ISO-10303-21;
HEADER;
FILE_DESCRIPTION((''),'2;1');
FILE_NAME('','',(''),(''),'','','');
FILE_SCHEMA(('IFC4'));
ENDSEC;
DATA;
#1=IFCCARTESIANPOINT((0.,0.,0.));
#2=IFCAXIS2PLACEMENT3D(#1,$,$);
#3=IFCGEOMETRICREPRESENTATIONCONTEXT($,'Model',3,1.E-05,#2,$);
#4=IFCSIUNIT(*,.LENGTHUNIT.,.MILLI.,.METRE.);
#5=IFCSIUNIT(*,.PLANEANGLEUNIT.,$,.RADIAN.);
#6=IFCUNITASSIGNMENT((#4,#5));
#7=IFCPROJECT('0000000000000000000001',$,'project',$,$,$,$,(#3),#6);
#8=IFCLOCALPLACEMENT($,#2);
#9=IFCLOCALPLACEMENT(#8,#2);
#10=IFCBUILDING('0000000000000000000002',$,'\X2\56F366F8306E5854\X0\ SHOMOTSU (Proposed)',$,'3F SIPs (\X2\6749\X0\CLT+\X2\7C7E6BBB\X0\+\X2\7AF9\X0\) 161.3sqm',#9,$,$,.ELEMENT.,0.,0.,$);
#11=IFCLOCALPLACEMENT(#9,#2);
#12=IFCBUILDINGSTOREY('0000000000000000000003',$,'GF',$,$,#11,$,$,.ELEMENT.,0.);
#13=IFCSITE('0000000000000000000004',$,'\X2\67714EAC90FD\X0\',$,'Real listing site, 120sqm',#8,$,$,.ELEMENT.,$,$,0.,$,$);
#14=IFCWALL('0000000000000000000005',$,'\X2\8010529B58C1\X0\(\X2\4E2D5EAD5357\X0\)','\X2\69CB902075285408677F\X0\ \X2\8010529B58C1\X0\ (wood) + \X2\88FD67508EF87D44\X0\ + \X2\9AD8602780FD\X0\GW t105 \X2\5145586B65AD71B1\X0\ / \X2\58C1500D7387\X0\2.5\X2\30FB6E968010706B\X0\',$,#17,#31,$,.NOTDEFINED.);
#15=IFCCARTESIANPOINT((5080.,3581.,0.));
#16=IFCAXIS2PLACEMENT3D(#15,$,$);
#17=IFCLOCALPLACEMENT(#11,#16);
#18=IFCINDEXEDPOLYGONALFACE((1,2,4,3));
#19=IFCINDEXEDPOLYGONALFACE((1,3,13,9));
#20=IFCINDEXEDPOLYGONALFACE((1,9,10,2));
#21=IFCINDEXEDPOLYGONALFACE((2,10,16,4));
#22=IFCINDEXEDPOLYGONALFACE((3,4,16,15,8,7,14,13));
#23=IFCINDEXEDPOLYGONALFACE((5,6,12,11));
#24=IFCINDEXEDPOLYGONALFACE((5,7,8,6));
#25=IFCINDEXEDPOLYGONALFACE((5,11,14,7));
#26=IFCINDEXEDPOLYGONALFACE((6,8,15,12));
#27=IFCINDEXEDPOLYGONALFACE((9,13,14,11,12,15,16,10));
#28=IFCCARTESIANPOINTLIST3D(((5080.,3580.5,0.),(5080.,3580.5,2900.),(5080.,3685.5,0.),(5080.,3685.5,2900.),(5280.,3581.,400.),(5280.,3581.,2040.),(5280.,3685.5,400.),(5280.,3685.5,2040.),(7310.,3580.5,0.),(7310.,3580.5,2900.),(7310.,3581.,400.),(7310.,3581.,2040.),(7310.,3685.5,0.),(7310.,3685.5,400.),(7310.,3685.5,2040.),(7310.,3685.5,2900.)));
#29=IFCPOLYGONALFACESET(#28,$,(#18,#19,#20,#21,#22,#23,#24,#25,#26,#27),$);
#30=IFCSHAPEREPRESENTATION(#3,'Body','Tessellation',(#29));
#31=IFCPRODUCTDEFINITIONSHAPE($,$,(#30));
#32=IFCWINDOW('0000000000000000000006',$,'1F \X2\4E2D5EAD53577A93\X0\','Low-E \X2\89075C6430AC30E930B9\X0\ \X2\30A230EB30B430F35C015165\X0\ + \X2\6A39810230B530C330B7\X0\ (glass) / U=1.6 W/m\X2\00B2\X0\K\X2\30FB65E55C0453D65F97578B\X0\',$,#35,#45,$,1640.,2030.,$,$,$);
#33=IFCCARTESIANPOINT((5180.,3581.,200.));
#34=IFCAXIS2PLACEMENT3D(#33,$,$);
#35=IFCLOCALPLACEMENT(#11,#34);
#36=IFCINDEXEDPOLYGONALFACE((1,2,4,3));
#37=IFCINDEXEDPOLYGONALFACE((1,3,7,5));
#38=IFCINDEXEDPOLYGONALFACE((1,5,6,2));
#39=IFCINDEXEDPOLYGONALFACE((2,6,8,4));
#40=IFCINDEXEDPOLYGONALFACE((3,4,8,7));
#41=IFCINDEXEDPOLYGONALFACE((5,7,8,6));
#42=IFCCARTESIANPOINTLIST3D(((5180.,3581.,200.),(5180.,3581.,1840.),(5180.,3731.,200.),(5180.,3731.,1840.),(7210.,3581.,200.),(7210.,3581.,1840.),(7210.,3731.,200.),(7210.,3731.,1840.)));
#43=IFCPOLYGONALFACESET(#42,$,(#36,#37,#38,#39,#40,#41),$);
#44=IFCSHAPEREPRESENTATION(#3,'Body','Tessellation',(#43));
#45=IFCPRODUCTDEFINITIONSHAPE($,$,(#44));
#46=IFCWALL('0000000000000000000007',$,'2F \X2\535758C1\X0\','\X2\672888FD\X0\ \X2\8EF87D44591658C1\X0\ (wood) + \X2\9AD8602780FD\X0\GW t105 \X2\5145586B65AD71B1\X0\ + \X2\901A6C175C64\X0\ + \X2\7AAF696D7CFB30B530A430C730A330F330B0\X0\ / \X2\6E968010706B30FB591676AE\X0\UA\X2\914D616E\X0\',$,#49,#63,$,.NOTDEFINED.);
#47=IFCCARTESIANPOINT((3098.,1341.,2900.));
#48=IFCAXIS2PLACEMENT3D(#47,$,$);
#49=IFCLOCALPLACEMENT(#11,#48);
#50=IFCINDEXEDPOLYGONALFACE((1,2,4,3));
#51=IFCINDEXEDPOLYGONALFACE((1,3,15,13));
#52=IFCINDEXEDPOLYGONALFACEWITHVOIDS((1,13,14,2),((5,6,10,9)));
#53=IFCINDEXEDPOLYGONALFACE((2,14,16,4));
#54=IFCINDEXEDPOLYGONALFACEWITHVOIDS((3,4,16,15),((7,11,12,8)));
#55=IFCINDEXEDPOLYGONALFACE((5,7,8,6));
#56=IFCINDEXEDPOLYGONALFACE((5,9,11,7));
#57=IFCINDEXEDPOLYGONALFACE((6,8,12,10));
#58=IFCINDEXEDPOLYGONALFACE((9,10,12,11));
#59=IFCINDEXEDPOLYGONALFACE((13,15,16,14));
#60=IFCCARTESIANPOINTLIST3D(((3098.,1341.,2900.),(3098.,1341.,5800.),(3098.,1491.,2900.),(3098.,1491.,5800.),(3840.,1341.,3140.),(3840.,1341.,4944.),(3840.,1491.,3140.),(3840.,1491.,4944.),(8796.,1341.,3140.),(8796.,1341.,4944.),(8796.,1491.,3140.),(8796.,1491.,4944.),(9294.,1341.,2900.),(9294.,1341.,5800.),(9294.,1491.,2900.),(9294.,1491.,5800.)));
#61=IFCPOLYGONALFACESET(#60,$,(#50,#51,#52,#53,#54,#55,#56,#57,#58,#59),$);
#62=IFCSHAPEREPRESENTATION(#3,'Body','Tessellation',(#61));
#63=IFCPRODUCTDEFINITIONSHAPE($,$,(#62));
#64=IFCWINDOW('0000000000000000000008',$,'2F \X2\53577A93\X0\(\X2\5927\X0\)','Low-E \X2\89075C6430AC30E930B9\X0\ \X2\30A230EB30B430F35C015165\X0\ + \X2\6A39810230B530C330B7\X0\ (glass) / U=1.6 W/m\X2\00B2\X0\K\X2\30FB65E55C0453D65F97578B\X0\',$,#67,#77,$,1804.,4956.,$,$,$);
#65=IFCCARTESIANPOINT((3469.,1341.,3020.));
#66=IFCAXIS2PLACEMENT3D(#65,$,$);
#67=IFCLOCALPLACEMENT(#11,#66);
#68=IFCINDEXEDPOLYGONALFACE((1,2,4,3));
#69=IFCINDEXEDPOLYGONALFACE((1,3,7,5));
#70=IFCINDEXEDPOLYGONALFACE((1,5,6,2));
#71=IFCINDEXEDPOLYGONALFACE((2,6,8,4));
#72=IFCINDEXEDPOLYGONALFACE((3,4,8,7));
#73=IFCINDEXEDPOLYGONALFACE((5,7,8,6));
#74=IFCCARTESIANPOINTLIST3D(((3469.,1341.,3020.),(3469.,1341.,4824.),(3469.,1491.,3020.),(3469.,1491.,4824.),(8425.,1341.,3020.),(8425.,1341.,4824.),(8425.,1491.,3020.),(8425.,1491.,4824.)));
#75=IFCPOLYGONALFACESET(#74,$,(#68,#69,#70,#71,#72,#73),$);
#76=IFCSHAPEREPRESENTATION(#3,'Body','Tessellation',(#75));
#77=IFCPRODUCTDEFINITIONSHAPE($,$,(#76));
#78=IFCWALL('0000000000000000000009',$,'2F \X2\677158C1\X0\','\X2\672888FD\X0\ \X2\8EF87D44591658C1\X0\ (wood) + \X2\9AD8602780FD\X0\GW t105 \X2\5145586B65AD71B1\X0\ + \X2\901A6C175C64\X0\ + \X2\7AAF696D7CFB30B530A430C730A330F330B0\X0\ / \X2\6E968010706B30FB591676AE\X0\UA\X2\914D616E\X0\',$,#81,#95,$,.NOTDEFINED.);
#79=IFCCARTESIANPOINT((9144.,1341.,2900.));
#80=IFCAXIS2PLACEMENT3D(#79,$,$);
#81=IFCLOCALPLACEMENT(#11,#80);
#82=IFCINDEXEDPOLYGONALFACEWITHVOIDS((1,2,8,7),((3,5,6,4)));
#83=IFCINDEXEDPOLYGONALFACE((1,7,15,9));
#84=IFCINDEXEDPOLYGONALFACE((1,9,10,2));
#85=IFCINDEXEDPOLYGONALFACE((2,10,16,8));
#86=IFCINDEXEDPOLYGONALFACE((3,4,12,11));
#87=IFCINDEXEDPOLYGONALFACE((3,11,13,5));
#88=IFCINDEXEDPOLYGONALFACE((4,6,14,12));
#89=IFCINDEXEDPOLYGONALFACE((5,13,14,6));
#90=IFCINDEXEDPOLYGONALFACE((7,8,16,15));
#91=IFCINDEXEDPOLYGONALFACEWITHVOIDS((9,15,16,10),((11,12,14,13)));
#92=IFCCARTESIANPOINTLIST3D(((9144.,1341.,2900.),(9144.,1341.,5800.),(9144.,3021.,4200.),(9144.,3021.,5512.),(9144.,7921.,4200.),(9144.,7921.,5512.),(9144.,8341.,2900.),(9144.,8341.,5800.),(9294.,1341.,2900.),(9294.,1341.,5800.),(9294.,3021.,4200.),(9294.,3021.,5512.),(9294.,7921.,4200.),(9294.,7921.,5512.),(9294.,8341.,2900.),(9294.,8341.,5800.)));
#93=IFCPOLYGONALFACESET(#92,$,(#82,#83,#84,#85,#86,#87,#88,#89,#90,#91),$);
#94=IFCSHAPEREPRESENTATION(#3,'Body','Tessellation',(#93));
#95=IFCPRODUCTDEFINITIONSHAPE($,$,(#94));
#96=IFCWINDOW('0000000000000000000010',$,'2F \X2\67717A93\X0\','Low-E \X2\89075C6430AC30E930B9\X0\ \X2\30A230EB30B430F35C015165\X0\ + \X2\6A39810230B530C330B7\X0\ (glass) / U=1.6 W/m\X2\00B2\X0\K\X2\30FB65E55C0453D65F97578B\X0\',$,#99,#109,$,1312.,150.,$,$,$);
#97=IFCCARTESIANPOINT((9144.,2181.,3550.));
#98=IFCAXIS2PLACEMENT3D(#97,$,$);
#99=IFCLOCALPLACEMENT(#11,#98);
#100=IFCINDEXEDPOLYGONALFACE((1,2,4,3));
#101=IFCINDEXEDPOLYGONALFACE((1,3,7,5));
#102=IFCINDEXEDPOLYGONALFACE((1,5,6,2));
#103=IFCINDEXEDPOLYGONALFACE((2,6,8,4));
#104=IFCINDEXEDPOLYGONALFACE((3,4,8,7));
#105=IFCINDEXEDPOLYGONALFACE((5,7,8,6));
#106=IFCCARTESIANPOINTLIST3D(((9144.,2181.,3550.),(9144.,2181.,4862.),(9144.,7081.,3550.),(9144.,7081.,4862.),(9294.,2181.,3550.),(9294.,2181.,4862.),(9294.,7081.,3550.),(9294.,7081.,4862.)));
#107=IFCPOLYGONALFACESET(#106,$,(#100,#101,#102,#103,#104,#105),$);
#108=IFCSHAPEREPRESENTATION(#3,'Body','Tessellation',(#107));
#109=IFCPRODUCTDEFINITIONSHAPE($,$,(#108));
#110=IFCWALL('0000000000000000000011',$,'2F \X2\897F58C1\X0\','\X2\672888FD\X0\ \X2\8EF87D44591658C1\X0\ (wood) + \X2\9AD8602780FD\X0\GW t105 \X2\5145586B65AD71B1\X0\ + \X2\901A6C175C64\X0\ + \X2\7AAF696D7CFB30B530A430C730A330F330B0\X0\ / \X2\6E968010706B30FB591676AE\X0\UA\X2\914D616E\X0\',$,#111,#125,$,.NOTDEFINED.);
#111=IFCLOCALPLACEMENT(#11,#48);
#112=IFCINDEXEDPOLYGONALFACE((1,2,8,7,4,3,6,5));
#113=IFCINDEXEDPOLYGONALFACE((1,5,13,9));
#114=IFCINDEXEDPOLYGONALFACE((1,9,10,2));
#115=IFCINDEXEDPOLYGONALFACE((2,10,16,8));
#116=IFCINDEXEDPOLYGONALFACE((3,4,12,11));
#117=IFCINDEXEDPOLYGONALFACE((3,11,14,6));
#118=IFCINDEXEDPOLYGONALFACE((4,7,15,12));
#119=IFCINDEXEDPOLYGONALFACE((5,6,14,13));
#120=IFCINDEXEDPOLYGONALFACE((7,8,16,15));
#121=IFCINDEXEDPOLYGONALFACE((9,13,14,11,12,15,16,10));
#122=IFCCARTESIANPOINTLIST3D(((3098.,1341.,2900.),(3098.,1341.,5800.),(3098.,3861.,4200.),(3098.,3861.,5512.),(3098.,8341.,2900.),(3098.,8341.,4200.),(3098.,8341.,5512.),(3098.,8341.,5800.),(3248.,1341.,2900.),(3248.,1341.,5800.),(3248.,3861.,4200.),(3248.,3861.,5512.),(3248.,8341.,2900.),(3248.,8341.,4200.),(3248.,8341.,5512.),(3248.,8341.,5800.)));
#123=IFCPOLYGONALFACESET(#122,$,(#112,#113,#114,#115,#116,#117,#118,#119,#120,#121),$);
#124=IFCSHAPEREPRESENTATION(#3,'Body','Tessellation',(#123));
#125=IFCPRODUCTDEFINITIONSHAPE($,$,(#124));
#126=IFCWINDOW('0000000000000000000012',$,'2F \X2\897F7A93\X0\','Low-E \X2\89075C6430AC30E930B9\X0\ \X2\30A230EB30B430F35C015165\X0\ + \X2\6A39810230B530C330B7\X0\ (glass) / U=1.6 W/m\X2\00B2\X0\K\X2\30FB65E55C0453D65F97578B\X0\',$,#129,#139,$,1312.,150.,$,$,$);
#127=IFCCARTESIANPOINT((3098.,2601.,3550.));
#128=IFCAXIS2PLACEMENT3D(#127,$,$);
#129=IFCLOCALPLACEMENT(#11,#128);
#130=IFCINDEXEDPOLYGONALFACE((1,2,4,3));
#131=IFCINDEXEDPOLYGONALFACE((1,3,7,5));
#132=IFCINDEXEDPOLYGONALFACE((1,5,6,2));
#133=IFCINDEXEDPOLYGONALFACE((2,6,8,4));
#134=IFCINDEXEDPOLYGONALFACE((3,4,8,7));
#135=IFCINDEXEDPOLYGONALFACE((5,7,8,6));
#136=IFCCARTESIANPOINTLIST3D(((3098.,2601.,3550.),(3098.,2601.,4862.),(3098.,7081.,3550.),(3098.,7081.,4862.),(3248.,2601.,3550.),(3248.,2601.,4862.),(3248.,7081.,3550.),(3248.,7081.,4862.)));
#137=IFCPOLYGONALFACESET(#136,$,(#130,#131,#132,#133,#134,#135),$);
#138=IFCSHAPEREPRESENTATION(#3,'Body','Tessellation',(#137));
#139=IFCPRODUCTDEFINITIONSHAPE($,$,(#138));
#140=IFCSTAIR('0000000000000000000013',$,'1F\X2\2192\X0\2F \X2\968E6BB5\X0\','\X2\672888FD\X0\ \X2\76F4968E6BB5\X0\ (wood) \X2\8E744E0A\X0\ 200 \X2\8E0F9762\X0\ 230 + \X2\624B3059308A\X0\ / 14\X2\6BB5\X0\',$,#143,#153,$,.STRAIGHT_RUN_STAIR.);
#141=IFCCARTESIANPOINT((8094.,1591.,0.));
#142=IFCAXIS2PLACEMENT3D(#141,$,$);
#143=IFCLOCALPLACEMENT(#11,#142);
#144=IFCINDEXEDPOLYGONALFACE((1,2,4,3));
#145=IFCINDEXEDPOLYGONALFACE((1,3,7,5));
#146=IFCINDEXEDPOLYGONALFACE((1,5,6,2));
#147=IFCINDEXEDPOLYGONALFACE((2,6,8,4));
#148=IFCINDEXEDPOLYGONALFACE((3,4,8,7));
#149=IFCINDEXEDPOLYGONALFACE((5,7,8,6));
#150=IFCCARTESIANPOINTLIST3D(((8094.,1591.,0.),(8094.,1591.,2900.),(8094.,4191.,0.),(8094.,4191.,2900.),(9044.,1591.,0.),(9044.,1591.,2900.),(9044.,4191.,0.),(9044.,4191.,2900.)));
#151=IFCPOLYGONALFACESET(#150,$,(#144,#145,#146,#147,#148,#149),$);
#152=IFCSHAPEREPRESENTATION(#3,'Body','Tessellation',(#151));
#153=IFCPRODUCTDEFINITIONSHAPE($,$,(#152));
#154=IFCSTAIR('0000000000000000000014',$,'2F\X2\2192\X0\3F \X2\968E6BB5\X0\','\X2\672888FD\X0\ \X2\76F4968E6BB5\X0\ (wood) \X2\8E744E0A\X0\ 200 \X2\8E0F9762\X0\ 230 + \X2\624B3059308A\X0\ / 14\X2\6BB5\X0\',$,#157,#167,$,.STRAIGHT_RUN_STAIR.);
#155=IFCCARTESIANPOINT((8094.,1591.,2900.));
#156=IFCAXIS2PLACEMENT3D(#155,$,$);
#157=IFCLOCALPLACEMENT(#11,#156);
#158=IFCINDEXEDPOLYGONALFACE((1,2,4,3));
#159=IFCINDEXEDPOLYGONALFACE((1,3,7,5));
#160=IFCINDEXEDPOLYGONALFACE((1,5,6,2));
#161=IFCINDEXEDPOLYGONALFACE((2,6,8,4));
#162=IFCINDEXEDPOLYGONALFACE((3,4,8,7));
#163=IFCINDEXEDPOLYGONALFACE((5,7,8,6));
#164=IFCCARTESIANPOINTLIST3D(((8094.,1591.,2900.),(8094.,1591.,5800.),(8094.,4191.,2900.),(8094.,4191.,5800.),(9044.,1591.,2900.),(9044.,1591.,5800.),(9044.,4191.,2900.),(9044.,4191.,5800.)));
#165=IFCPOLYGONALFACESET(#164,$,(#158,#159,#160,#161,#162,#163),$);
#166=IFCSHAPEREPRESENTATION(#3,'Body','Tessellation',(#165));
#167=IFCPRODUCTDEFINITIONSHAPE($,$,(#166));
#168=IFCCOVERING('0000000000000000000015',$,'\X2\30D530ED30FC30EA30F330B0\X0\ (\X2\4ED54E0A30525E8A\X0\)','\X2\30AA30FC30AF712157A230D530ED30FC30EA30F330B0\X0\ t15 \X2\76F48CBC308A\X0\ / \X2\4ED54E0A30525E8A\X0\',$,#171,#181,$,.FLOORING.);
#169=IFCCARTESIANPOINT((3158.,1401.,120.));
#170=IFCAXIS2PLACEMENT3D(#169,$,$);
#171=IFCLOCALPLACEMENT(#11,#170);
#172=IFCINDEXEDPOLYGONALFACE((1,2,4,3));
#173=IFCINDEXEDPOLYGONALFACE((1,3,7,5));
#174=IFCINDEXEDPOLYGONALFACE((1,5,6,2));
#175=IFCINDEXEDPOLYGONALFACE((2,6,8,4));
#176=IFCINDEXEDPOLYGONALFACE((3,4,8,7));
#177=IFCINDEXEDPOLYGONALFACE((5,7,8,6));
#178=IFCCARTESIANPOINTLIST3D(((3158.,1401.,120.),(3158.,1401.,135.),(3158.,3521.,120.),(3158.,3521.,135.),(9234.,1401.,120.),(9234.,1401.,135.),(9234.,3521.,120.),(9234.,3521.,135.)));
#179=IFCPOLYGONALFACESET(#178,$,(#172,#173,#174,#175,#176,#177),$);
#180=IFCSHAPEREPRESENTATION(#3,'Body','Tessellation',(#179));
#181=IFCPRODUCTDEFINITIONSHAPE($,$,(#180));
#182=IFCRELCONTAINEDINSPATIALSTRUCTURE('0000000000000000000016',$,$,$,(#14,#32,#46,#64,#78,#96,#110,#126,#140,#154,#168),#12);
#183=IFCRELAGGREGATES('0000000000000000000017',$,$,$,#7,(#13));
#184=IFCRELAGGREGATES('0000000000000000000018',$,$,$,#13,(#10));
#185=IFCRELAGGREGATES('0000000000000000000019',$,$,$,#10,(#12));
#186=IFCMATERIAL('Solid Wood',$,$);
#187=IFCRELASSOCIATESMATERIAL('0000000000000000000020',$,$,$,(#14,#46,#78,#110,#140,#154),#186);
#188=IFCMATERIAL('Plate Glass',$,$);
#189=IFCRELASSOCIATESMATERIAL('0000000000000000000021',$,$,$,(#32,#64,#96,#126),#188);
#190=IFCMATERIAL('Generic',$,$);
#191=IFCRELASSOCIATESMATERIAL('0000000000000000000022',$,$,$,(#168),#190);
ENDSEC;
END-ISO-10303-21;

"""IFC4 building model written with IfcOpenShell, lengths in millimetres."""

from ifc_helpers import new_model, si_unit, frame, frame_2d, origin, place, context, project, spatial, rectangle, extrude, material, element, fill, save


model = new_model("IFC4")

# Units and contexts
model_context = context("Model", 3, precision=1e-05, world=origin())
ifc_project = project(units=[si_unit("LENGTHUNIT", "METRE", prefix="MILLI"), si_unit("PLANEANGLEUNIT", "RADIAN")], contexts=[model_context])

# Site, building, storey
site_placement = place(None, origin())
site = spatial("IfcSite", under=ifc_project, at=site_placement, Name="東京都", ObjectType="Real listing site, 120sqm", CompositionType="ELEMENT", RefElevation=0.0)
building_placement = place(site_placement, origin())
building = spatial("IfcBuilding", under=site, at=building_placement, Name="図書の塔 SHOMOTSU (Proposed)", ObjectType="3F SIPs (杉CLT+籾殻+竹) 161.3sqm", CompositionType="ELEMENT", ElevationOfRefHeight=0.0, ElevationOfTerrain=0.0)
storey_placement = place(building_placement, origin())
storey = spatial("IfcBuildingStorey", under=building, at=storey_placement, Name="GF", CompositionType="ELEMENT", Elevation=0.0)

# Shared definitions
ifc_material_1 = material(Name="Solid Wood")

# Shared definitions
ifc_material_2 = material(Name="Plate Glass")

# Walls, openings, windows
wall_1_placement = place(storey_placement, frame((5080.0, 3581.0, 0.0)))
wall_1 = element("IfcWall", 1, at=wall_1_placement, inside=storey, material=ifc_material_1, Name="耐力壁(中庭南)", Description="構造用合板 耐力壁 (wood) + 製材軸組 + 高性能GW t105 充填断熱 / 壁倍率2.5・準耐火", PredefinedType="NOTDEFINED", context=model_context, shape_type="SweptSolid", body=[
    extrude(rectangle(XDim=2230.0, YDim=105.0, at=frame_2d((1115.0, 52.0))), frame((5080.0, 3581.0, 0.0)), (0.0, 0.0, 1.0), 2900.0),
])
opening_1_placement = place(storey_placement, frame((5180.0, 3581.0, 200.0)))
opening_1 = element("IfcOpeningElement", 2, at=opening_1_placement, cuts=wall_1, PredefinedType="NOTDEFINED", context=model_context, shape_type="SweptSolid", body=[
    extrude(rectangle(XDim=2030.0, YDim=150.0, at=frame_2d((1015.0, 75.0))), frame((5180.0, 3581.0, 200.0)), (0.0, 0.0, 1.0), 1640.0),
])
window_1_placement = place(storey_placement, frame((5180.0, 3581.0, 200.0)))
window_1 = element("IfcWindow", 3, at=window_1_placement, inside=storey, material=ifc_material_2, Name="1F 中庭南窓", Description="Low-E 複層ガラス アルゴン封入 + 樹脂サッシ (glass) / U=1.6 W/m²K・日射取得型", OverallHeight=1640.0, OverallWidth=2030.0, context=model_context, shape_type="SweptSolid", body=[
    extrude(rectangle(XDim=2030.0, YDim=150.0, at=frame_2d((1015.0, 75.0))), frame((5180.0, 3581.0, 200.0)), (0.0, 0.0, 1.0), 1640.0),
])
fill(opening_1, window_1)
wall_2_placement = place(storey_placement, frame((3098.0, 1341.0, 2900.0)))
wall_2 = element("IfcWall", 4, at=wall_2_placement, inside=storey, material=ifc_material_1, Name="2F 南壁", Description="木製 軸組外壁 (wood) + 高性能GW t105 充填断熱 + 通気層 + 窯業系サイディング / 準耐火・外皮UA配慮", PredefinedType="NOTDEFINED", context=model_context, shape_type="SweptSolid", body=[
    extrude(rectangle(XDim=6196.0, YDim=150.0, at=frame_2d((3098.0, 75.0))), frame((3098.0, 1341.0, 2900.0)), (0.0, 0.0, 1.0), 2900.0),
])
opening_2_placement = place(storey_placement, frame((3469.0, 1341.0, 3020.0)))
opening_2 = element("IfcOpeningElement", 5, at=opening_2_placement, cuts=wall_2, PredefinedType="NOTDEFINED", context=model_context, shape_type="SweptSolid", body=[
    extrude(rectangle(XDim=4956.0, YDim=150.0, at=frame_2d((2478.0, 75.0))), frame((3469.0, 1341.0, 3020.0)), (0.0, 0.0, 1.0), 1804.0),
])
window_2_placement = place(storey_placement, frame((3469.0, 1341.0, 3020.0)))
window_2 = element("IfcWindow", 6, at=window_2_placement, inside=storey, material=ifc_material_2, Name="2F 南窓(大)", Description="Low-E 複層ガラス アルゴン封入 + 樹脂サッシ (glass) / U=1.6 W/m²K・日射取得型", OverallHeight=1804.0, OverallWidth=4956.0, context=model_context, shape_type="SweptSolid", body=[
    extrude(rectangle(XDim=4956.0, YDim=150.0, at=frame_2d((2478.0, 75.0))), frame((3469.0, 1341.0, 3020.0)), (0.0, 0.0, 1.0), 1804.0),
])
fill(opening_2, window_2)
wall_3_placement = place(storey_placement, frame((9144.0, 1341.0, 2900.0)))
wall_3 = element("IfcWall", 7, at=wall_3_placement, inside=storey, material=ifc_material_1, Name="2F 東壁", Description="木製 軸組外壁 (wood) + 高性能GW t105 充填断熱 + 通気層 + 窯業系サイディング / 準耐火・外皮UA配慮", PredefinedType="NOTDEFINED", context=model_context, shape_type="SweptSolid", body=[
    extrude(rectangle(XDim=150.0, YDim=7000.0, at=frame_2d((75.0, 3500.0))), frame((9144.0, 1341.0, 2900.0)), (0.0, 0.0, 1.0), 2900.0),
])
opening_3_placement = place(storey_placement, frame((9144.0, 2181.0, 3550.0)))
opening_3 = element("IfcOpeningElement", 8, at=opening_3_placement, cuts=wall_3, PredefinedType="NOTDEFINED", context=model_context, shape_type="SweptSolid", body=[
    extrude(rectangle(XDim=150.0, YDim=4900.0, at=frame_2d((75.0, 2450.0))), frame((9144.0, 2181.0, 3550.0)), (0.0, 0.0, 1.0), 1312.0),
])
window_3_placement = place(storey_placement, frame((9144.0, 2181.0, 3550.0)))
window_3 = element("IfcWindow", 9, at=window_3_placement, inside=storey, material=ifc_material_2, Name="2F 東窓", Description="Low-E 複層ガラス アルゴン封入 + 樹脂サッシ (glass) / U=1.6 W/m²K・日射取得型", OverallHeight=1312.0, OverallWidth=150.0, context=model_context, shape_type="SweptSolid", body=[
    extrude(rectangle(XDim=150.0, YDim=4900.0, at=frame_2d((75.0, 2450.0))), frame((9144.0, 2181.0, 3550.0)), (0.0, 0.0, 1.0), 1312.0),
])
fill(opening_3, window_3)
wall_4_placement = place(storey_placement, frame((3098.0, 1341.0, 2900.0)))
wall_4 = element("IfcWall", 10, at=wall_4_placement, inside=storey, material=ifc_material_1, Name="2F 西壁", Description="木製 軸組外壁 (wood) + 高性能GW t105 充填断熱 + 通気層 + 窯業系サイディング / 準耐火・外皮UA配慮", PredefinedType="NOTDEFINED", context=model_context, shape_type="SweptSolid", body=[
    extrude(rectangle(XDim=150.0, YDim=7000.0, at=frame_2d((75.0, 3500.0))), frame((3098.0, 1341.0, 2900.0)), (0.0, 0.0, 1.0), 2900.0),
])
opening_4_placement = place(storey_placement, frame((3098.0, 2601.0, 3550.0)))
opening_4 = element("IfcOpeningElement", 11, at=opening_4_placement, cuts=wall_4, PredefinedType="NOTDEFINED", context=model_context, shape_type="SweptSolid", body=[
    extrude(rectangle(XDim=150.0, YDim=4480.0, at=frame_2d((75.0, 2240.0))), frame((3098.0, 2601.0, 3550.0)), (0.0, 0.0, 1.0), 1312.0),
])
window_4_placement = place(storey_placement, frame((3098.0, 2601.0, 3550.0)))
window_4 = element("IfcWindow", 12, at=window_4_placement, inside=storey, material=ifc_material_2, Name="2F 西窓", Description="Low-E 複層ガラス アルゴン封入 + 樹脂サッシ (glass) / U=1.6 W/m²K・日射取得型", OverallHeight=1312.0, OverallWidth=150.0, context=model_context, shape_type="SweptSolid", body=[
    extrude(rectangle(XDim=150.0, YDim=4480.0, at=frame_2d((75.0, 2240.0))), frame((3098.0, 2601.0, 3550.0)), (0.0, 0.0, 1.0), 1312.0),
])
fill(opening_4, window_4)

# Stairs
stair_1_placement = place(storey_placement, frame((8094.0, 1591.0, 0.0)))
element("IfcStair", 13, at=stair_1_placement, inside=storey, material=ifc_material_1, Name="1F→2F 階段", Description="木製 直階段 (wood) 蹴上 200 踏面 230 + 手すり / 14段", PredefinedType="STRAIGHT_RUN_STAIR", context=model_context, shape_type="SweptSolid", body=[
    extrude(rectangle(XDim=950.0, YDim=2600.0, at=frame_2d((475.0, 1300.0))), frame((8094.0, 1591.0, 0.0)), (0.0, 0.0, 1.0), 2900.0),
])
stair_2_placement = place(storey_placement, frame((8094.0, 1591.0, 2900.0)))
element("IfcStair", 14, at=stair_2_placement, inside=storey, material=ifc_material_1, Name="2F→3F 階段", Description="木製 直階段 (wood) 蹴上 200 踏面 230 + 手すり / 14段", PredefinedType="STRAIGHT_RUN_STAIR", context=model_context, shape_type="SweptSolid", body=[
    extrude(rectangle(XDim=950.0, YDim=2600.0, at=frame_2d((475.0, 1300.0))), frame((8094.0, 1591.0, 2900.0)), (0.0, 0.0, 1.0), 2900.0),
])

# Covering
ifc_material_3 = material(Name="Generic")
covering_placement = place(storey_placement, frame((3158.0, 1401.0, 120.0)))
element("IfcCovering", 15, at=covering_placement, inside=storey, material=ifc_material_3, Name="フローリング (仕上げ床)", Description="オーク無垢フローリング t15 直貼り / 仕上げ床", PredefinedType="FLOORING", context=model_context, shape_type="SweptSolid", body=[
    extrude(rectangle(XDim=6076.0, YDim=2120.0, at=frame_2d((3038.0, 1060.0))), frame((3158.0, 1401.0, 120.0)), (0.0, 0.0, 1.0), 15.0),
])

save(model, "model.ifc")
